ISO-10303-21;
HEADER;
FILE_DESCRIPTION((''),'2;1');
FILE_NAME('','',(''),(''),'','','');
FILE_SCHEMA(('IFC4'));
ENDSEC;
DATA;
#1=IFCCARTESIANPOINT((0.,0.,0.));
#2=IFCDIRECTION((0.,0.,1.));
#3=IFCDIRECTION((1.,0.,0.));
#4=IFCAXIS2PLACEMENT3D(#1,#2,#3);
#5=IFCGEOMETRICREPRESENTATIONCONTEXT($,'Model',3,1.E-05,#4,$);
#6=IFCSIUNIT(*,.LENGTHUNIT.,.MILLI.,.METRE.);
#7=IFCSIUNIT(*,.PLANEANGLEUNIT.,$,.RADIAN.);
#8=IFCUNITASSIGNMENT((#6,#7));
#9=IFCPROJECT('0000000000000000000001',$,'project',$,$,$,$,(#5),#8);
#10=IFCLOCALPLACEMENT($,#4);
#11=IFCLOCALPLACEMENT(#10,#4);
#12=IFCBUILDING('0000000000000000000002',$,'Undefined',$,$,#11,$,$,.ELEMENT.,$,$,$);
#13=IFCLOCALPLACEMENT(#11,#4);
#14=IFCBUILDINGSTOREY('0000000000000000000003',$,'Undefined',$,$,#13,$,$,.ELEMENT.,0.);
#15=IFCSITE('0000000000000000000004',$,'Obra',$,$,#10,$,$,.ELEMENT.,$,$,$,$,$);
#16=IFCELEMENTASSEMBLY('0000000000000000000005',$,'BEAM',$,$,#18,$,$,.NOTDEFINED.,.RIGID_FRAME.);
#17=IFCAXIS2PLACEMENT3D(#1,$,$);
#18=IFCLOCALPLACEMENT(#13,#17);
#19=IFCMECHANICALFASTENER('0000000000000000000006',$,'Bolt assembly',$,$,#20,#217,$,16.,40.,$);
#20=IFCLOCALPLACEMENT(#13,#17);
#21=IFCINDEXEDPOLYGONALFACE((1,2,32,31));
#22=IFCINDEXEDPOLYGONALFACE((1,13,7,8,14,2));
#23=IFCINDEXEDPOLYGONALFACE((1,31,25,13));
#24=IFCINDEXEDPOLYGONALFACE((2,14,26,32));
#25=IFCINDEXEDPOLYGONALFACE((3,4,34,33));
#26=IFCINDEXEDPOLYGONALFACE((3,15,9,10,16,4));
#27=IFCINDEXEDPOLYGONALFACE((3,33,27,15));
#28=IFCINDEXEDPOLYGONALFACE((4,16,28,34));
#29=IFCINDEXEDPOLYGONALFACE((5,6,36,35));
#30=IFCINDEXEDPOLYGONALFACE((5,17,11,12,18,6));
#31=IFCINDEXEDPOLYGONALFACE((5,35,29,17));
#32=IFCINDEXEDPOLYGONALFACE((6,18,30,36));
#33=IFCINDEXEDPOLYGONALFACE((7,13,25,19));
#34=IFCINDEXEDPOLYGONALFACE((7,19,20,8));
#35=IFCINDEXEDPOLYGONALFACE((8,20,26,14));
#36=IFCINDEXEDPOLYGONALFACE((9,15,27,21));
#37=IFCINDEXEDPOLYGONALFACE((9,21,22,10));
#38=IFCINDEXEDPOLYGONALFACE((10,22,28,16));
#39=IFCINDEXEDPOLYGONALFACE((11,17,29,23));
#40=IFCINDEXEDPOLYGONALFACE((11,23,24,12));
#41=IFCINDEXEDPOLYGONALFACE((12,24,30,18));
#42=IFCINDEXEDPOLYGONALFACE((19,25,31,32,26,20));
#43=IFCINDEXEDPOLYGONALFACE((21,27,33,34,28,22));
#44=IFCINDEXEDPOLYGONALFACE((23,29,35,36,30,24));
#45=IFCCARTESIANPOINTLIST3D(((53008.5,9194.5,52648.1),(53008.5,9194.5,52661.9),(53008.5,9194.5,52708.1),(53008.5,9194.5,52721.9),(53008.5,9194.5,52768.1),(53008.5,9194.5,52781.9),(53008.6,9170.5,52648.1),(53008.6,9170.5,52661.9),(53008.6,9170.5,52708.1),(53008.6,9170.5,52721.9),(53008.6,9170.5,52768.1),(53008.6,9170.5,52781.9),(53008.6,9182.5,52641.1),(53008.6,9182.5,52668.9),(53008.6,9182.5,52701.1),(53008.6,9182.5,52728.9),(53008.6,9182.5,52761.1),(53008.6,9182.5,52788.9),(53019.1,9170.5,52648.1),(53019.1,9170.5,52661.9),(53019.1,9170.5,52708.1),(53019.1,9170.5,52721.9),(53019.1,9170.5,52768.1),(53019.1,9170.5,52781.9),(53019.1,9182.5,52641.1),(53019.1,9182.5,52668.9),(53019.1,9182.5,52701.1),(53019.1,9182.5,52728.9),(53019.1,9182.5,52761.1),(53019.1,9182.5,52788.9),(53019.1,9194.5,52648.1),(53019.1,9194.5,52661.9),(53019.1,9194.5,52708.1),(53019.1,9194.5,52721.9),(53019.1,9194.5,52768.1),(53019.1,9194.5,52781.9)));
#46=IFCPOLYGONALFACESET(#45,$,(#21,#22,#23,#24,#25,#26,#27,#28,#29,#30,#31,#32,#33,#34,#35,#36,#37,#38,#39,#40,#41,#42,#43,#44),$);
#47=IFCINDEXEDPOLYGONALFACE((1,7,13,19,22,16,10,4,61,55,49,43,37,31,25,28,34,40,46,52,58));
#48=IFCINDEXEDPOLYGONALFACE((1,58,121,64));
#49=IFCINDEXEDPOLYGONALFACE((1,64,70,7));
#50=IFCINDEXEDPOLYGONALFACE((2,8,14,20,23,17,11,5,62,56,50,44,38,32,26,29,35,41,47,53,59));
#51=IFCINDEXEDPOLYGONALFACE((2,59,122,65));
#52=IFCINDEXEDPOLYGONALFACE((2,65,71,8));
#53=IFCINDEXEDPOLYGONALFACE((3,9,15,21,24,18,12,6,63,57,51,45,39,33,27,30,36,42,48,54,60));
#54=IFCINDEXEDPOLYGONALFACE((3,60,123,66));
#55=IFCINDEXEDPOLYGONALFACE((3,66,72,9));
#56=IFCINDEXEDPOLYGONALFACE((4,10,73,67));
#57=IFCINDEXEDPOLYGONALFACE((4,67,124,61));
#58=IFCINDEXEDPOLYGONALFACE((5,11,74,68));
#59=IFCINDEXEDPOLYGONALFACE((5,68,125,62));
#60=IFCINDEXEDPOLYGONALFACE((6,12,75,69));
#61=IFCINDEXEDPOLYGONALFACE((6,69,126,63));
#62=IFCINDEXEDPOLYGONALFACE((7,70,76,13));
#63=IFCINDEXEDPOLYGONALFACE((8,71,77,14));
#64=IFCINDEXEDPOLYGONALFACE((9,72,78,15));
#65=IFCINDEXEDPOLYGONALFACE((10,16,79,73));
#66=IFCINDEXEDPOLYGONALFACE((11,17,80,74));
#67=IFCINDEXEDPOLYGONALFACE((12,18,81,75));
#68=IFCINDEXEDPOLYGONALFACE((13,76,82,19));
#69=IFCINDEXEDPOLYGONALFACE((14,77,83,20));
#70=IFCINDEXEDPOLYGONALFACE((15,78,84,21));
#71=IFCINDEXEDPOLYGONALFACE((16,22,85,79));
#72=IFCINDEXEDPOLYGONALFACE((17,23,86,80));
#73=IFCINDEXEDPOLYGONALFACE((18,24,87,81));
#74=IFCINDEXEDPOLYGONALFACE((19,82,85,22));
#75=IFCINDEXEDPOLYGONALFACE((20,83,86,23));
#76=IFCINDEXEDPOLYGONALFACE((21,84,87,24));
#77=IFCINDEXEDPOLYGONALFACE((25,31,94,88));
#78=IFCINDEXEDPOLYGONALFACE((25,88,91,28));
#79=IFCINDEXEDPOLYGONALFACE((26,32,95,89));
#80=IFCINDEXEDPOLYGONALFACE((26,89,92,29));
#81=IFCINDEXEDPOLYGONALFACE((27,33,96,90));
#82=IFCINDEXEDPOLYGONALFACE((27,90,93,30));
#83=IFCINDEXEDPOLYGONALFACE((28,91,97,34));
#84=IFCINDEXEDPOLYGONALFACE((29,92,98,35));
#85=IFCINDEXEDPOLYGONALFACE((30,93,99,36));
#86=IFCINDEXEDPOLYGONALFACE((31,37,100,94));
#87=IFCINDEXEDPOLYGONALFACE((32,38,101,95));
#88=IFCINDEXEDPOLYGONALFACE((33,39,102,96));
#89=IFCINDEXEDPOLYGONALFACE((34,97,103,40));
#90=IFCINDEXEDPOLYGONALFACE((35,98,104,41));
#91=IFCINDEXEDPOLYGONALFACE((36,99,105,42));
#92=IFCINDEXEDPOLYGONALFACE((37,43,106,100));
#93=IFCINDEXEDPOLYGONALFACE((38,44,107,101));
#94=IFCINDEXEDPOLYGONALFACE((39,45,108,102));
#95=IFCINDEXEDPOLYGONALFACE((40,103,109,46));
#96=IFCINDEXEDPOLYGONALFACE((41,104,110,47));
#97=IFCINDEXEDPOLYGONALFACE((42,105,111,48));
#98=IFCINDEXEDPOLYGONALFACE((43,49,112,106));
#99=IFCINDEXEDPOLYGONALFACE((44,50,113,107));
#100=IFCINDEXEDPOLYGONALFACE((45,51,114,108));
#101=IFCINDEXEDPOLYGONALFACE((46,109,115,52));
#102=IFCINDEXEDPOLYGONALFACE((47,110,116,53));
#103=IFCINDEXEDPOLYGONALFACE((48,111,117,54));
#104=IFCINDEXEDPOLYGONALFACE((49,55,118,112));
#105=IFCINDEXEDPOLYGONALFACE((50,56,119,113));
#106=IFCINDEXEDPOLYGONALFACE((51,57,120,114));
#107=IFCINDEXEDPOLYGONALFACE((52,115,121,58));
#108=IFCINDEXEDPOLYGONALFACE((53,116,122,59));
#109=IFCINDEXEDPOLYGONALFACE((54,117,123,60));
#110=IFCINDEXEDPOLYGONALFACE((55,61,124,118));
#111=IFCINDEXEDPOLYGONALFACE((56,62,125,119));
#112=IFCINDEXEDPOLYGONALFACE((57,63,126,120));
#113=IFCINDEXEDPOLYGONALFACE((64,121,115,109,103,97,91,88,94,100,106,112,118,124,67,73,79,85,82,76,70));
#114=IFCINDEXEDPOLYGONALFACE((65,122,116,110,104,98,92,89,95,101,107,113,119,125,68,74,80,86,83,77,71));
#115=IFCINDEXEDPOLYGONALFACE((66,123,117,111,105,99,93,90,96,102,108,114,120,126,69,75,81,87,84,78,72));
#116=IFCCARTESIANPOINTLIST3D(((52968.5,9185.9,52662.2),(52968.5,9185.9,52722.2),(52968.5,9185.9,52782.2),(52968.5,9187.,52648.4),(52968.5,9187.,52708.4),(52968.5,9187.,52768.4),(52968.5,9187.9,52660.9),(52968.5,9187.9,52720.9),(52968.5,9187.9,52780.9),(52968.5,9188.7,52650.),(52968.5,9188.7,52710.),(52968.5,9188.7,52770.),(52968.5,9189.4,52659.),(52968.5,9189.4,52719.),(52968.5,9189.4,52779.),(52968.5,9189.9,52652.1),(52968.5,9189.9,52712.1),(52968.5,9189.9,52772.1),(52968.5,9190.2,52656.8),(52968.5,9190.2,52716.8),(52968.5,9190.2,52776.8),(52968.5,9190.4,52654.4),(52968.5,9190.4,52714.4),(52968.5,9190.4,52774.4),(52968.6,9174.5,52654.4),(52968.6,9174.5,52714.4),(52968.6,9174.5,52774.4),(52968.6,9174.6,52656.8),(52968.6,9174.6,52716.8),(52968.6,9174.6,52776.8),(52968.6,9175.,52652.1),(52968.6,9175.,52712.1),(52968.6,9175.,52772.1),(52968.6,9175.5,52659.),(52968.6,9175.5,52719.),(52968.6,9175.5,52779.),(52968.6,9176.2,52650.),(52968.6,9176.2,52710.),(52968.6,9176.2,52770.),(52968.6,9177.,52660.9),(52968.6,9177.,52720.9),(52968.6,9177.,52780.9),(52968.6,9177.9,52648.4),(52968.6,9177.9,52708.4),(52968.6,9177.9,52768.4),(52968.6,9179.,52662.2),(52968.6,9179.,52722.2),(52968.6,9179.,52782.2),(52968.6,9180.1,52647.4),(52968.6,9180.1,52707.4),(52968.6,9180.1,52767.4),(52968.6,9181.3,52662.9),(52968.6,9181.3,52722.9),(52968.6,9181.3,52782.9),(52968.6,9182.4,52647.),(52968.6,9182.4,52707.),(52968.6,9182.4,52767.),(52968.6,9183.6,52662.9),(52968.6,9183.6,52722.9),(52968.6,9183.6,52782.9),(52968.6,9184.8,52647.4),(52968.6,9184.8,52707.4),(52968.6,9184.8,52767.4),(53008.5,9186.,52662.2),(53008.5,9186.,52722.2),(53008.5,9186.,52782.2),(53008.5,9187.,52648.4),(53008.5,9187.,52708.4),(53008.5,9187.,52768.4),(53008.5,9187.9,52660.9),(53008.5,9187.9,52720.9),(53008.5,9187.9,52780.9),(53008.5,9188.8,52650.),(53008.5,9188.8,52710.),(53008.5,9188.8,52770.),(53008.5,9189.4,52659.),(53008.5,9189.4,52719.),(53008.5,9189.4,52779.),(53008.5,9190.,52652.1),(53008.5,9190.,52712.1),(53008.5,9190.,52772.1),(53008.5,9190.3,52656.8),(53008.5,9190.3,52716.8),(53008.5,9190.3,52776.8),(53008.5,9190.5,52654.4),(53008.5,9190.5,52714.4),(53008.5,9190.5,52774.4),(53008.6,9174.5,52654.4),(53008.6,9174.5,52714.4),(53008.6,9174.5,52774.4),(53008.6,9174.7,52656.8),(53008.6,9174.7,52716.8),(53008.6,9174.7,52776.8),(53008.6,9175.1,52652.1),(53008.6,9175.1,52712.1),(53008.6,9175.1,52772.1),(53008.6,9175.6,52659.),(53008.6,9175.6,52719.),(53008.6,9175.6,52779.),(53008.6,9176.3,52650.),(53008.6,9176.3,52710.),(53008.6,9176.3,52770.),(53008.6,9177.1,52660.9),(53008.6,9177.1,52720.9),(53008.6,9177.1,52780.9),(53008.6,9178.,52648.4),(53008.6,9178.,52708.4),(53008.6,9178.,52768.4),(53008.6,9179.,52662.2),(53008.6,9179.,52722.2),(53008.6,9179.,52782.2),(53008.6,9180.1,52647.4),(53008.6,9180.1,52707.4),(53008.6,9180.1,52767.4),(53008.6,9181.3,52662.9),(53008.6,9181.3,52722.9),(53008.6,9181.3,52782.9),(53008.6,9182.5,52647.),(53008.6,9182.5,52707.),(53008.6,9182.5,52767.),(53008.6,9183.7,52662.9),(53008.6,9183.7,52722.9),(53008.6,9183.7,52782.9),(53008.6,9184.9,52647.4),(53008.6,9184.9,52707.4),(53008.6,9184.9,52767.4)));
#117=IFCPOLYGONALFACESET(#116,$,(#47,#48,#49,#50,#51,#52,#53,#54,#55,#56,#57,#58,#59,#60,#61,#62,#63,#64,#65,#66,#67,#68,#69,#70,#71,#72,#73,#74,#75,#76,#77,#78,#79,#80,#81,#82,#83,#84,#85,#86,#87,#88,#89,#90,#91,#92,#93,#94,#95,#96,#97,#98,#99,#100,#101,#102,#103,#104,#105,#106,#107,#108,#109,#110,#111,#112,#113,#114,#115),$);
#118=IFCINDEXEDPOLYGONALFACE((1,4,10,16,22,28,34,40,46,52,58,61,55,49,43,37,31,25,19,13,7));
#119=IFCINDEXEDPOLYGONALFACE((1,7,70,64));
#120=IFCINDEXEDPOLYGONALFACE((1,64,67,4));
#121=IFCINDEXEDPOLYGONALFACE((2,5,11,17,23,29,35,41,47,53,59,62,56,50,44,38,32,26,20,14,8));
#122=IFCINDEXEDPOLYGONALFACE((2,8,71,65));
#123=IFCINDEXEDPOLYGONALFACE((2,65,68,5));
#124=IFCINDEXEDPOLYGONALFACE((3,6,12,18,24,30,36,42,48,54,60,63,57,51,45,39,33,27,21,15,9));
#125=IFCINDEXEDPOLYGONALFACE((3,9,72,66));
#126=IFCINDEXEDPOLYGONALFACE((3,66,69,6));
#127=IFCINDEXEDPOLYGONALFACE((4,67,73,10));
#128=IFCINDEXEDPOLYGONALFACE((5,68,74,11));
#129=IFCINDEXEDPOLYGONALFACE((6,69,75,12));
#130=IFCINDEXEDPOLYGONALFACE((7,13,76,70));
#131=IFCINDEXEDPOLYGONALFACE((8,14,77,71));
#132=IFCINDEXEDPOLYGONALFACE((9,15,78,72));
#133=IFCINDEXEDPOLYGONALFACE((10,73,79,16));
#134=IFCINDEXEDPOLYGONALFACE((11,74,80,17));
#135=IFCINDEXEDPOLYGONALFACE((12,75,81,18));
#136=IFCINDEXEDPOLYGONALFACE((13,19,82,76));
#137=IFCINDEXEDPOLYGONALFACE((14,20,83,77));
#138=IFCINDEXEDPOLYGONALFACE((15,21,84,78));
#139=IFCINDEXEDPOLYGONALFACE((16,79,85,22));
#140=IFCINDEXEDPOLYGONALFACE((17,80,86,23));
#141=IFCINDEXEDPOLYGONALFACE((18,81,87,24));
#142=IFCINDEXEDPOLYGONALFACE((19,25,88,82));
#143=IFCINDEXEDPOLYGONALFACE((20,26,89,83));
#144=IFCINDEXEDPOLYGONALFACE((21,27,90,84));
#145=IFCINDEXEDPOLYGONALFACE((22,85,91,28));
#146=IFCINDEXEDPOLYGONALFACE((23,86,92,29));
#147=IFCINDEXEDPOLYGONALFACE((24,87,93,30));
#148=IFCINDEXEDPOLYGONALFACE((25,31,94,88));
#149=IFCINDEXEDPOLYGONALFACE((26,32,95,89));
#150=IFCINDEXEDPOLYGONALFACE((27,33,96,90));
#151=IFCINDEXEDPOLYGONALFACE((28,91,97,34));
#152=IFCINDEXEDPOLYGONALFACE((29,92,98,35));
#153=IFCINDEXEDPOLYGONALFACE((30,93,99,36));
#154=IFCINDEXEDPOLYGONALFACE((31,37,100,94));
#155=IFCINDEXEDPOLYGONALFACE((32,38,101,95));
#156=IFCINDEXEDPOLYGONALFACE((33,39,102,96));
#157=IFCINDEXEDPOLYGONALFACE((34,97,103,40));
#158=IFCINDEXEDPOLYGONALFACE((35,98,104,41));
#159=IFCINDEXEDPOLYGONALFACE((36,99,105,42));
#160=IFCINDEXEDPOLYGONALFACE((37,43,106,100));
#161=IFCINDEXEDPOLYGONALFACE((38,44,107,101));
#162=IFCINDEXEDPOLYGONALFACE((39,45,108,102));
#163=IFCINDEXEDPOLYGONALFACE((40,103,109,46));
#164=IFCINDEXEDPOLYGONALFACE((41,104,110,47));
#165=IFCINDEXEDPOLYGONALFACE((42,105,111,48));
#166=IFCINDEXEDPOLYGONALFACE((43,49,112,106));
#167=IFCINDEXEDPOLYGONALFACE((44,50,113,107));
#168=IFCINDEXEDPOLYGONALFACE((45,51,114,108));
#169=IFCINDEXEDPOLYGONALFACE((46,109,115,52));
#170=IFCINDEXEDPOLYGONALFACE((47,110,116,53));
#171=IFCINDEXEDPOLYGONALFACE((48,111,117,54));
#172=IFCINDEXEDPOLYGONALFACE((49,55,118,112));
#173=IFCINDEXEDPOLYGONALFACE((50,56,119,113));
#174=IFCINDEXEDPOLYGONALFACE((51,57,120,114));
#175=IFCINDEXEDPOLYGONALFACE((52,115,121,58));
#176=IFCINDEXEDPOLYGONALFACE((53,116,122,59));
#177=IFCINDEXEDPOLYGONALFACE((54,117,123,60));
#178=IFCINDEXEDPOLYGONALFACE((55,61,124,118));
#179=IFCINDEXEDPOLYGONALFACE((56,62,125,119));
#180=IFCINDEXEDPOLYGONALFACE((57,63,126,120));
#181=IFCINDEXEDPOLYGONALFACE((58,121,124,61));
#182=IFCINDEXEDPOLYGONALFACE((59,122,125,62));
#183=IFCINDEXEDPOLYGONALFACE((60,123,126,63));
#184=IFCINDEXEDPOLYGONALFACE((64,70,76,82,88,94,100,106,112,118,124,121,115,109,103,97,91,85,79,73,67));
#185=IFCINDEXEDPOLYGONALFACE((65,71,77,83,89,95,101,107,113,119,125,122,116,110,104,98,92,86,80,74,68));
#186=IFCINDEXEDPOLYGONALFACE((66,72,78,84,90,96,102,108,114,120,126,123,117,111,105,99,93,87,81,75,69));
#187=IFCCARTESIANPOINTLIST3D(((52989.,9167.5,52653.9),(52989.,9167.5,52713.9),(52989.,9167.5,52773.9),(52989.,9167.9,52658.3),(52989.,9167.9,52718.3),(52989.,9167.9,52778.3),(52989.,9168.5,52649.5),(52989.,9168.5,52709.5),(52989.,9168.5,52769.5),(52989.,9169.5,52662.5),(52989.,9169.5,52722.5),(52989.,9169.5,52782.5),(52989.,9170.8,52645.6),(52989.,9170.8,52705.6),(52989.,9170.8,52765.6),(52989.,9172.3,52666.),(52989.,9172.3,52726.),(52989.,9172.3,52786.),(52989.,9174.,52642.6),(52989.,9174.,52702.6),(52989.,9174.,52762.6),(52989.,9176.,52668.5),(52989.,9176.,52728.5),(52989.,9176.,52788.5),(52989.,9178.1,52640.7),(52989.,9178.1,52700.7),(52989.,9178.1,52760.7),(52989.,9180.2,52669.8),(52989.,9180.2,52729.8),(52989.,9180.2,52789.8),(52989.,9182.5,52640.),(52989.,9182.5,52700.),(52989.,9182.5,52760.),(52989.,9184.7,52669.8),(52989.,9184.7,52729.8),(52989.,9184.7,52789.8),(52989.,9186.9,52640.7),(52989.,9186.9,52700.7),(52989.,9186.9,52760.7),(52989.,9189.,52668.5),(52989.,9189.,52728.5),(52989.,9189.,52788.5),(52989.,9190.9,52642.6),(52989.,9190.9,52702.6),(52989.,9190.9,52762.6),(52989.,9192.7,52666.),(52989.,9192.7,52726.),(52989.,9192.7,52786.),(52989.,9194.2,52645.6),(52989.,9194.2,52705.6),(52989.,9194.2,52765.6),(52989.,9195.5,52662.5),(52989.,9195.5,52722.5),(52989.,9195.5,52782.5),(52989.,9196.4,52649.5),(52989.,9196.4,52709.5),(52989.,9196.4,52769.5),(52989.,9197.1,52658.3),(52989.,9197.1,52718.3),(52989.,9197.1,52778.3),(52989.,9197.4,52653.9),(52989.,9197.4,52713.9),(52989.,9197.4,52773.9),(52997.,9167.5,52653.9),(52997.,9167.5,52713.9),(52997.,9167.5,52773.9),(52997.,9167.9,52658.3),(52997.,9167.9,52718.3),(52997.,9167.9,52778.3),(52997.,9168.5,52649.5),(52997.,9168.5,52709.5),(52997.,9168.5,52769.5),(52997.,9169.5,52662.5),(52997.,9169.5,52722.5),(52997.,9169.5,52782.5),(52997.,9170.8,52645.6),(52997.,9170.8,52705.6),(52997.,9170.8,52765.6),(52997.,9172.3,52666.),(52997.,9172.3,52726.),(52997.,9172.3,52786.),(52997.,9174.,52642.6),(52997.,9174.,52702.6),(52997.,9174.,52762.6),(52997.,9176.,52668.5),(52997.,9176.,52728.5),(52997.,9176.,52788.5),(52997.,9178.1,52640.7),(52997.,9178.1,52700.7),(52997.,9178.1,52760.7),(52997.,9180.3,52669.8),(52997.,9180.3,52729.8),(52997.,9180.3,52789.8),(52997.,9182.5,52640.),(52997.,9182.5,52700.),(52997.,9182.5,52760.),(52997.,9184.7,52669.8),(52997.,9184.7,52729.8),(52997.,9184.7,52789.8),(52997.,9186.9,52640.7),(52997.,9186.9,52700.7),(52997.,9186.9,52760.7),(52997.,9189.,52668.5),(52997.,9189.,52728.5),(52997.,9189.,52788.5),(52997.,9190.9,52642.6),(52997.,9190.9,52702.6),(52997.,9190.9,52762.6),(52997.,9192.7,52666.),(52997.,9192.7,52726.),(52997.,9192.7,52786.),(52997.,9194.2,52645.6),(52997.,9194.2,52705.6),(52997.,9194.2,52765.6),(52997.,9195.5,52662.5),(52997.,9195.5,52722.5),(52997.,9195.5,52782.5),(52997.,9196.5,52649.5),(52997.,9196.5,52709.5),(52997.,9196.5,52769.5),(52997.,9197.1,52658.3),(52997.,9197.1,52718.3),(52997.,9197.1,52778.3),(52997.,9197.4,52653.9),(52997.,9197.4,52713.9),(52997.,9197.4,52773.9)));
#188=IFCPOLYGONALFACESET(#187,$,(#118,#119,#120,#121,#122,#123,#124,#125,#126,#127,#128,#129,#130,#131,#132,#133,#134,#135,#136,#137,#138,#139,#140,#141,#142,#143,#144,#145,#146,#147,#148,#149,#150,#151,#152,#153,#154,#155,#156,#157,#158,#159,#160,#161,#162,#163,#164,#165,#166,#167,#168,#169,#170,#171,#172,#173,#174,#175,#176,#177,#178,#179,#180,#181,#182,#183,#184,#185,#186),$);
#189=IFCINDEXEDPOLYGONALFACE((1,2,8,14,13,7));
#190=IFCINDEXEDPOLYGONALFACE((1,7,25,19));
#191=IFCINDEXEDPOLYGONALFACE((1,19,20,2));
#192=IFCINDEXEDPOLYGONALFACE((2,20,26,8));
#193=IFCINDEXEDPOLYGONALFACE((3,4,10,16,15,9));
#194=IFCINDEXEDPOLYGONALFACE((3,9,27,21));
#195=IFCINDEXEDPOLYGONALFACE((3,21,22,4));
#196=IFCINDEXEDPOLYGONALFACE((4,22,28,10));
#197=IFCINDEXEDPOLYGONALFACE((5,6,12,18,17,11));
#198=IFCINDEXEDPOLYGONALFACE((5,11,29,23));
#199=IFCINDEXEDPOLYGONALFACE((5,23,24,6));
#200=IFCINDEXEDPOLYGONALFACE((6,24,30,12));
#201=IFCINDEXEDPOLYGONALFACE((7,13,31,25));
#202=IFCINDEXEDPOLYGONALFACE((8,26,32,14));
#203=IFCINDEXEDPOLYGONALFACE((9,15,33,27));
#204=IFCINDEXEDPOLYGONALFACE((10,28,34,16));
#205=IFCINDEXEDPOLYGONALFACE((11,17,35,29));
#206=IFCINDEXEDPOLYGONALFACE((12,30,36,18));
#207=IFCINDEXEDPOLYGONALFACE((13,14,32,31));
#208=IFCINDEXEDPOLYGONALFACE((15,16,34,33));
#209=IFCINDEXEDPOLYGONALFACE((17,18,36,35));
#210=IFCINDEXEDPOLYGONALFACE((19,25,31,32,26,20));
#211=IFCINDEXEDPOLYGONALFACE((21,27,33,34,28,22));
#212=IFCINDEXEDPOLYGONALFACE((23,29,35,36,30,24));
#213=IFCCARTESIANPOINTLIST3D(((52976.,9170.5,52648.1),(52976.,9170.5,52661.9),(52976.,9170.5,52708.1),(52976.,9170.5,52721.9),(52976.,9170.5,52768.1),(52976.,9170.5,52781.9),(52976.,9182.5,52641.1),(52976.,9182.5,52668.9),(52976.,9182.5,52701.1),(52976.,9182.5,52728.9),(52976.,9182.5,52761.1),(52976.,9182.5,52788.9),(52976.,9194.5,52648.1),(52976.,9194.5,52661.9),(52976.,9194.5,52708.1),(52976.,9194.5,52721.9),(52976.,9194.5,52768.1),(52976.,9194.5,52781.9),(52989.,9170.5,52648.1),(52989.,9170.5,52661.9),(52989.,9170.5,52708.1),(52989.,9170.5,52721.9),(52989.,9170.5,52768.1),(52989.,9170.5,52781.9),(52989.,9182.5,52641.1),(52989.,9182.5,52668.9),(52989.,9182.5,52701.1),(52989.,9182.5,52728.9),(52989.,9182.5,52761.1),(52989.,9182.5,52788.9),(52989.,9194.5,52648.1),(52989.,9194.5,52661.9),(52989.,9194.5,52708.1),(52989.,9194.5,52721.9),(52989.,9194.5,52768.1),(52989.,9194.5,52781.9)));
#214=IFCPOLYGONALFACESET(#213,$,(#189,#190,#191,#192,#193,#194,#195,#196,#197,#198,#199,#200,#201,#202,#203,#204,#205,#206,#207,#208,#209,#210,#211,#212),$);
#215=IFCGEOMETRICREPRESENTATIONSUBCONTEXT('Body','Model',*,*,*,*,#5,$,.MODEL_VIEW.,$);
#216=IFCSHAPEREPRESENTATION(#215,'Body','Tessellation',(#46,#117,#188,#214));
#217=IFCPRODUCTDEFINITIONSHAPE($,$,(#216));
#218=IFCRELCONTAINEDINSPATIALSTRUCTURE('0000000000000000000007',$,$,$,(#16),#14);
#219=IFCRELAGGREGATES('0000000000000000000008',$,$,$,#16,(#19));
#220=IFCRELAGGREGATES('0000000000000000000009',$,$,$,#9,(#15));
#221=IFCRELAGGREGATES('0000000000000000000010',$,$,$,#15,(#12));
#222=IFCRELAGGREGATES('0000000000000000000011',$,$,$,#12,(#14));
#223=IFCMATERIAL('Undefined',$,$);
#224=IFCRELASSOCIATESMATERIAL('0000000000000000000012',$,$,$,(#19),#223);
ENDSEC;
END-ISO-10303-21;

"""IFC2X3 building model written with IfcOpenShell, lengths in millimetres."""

from ifc_helpers import new_model, si_unit, frame, origin_with_axes, origin_2d_with_axis, place, context, subcontext, project, spatial, polyline, circle, outline, extrude, source, transform, mapped, material, element, aggregate, save


model = new_model("IFC2X3")

# Units and contexts
model_context = context("Model", 3, precision=1e-05, world=origin_with_axes())
body_context = subcontext(model_context, "Body", "Model", "MODEL_VIEW")
ifc_project = project(units=[si_unit("LENGTHUNIT", "METRE", prefix="MILLI"), si_unit("PLANEANGLEUNIT", "RADIAN")], contexts=[model_context])

# Site, building, storey
site_placement = place(None, origin_with_axes())
site = spatial("IfcSite", under=ifc_project, at=site_placement, Name="Obra", CompositionType="ELEMENT")
building_placement = place(site_placement, origin_with_axes())
building = spatial("IfcBuilding", under=site, at=building_placement, Name="Undefined", CompositionType="ELEMENT")
storey_placement = place(building_placement, origin_with_axes())
storey = spatial("IfcBuildingStorey", under=building, at=storey_placement, Name="Undefined", CompositionType="ELEMENT", Elevation=0.0)

# Element assembly, mechanical fastener
assembly_1_placement = place(storey_placement, origin_with_axes())
assembly_1 = element("IfcElementAssembly", 1, at=assembly_1_placement, inside=storey, Name="BEAM", AssemblyPlace="NOTDEFINED", PredefinedType="RIGID_FRAME")
ifc_material_1 = material(Name="Undefined")
shared_shape_1 = source(origin_with_axes(), body_context, "Body", "SweptSolid", [
    extrude(outline(polyline([(13.9, 0.0), (6.9, 12.0), (-6.9, 12.0), (-13.9, 0.0), (-6.9, -12.0), (6.9, -12.0), (13.9, 0.0)])), frame((0.0, -19.7, 0.0), z_axis=(0.0, 1.0, 0.0), x_axis=(1.0, 0.0, 0.0)), (0.0, 0.0, 1.0), 10.6),
    extrude(circle(Radius=8.0, at=origin_2d_with_axis()), frame((0.0, -9.1, 0.0), z_axis=(0.0, 1.0, 0.0), x_axis=(1.0, 0.0, 0.0)), (0.0, 0.0, 1.0), 40.0),
    extrude(circle(Radius=15.0, at=origin_2d_with_axis()), frame((0.0, 2.5, 0.0), z_axis=(0.0, 1.0, 0.0), x_axis=(1.0, 0.0, 0.0)), (0.0, 0.0, 1.0), 8.0),
    extrude(outline(polyline([(13.9, 0.0), (6.9, 12.0), (-6.9, 12.0), (-13.9, 0.0), (-6.9, -12.0), (6.9, -12.0), (13.9, 0.0)])), frame((0.0, 10.5, 0.0), z_axis=(0.0, 1.0, 0.0), x_axis=(1.0, 0.0, 0.0)), (0.0, 0.0, 1.0), 13.0),
])
mechanical_fastener_1_placement = place(assembly_1_placement, frame((52999.5, 9132.5, 52835.0), z_axis=(-0.001508, 0.999999, 0.0), x_axis=(0.0, 0.0, -1.0)))
mechanical_fastener_1 = element("IfcMechanicalFastener", 2, at=mechanical_fastener_1_placement, material=ifc_material_1, Name="Bolt assembly", NominalDiameter=16.0, NominalLength=40.0, context=body_context, shape_type="MappedRepresentation", body=[
    mapped(shared_shape_1, transform((60.0, 0.0, 50.0))),
    mapped(shared_shape_1, transform((120.0, 0.0, 50.0))),
    mapped(shared_shape_1, transform((180.0, 0.0, 50.0))),
])
aggregate(assembly_1, [mechanical_fastener_1])

save(model, "model.ifc")
